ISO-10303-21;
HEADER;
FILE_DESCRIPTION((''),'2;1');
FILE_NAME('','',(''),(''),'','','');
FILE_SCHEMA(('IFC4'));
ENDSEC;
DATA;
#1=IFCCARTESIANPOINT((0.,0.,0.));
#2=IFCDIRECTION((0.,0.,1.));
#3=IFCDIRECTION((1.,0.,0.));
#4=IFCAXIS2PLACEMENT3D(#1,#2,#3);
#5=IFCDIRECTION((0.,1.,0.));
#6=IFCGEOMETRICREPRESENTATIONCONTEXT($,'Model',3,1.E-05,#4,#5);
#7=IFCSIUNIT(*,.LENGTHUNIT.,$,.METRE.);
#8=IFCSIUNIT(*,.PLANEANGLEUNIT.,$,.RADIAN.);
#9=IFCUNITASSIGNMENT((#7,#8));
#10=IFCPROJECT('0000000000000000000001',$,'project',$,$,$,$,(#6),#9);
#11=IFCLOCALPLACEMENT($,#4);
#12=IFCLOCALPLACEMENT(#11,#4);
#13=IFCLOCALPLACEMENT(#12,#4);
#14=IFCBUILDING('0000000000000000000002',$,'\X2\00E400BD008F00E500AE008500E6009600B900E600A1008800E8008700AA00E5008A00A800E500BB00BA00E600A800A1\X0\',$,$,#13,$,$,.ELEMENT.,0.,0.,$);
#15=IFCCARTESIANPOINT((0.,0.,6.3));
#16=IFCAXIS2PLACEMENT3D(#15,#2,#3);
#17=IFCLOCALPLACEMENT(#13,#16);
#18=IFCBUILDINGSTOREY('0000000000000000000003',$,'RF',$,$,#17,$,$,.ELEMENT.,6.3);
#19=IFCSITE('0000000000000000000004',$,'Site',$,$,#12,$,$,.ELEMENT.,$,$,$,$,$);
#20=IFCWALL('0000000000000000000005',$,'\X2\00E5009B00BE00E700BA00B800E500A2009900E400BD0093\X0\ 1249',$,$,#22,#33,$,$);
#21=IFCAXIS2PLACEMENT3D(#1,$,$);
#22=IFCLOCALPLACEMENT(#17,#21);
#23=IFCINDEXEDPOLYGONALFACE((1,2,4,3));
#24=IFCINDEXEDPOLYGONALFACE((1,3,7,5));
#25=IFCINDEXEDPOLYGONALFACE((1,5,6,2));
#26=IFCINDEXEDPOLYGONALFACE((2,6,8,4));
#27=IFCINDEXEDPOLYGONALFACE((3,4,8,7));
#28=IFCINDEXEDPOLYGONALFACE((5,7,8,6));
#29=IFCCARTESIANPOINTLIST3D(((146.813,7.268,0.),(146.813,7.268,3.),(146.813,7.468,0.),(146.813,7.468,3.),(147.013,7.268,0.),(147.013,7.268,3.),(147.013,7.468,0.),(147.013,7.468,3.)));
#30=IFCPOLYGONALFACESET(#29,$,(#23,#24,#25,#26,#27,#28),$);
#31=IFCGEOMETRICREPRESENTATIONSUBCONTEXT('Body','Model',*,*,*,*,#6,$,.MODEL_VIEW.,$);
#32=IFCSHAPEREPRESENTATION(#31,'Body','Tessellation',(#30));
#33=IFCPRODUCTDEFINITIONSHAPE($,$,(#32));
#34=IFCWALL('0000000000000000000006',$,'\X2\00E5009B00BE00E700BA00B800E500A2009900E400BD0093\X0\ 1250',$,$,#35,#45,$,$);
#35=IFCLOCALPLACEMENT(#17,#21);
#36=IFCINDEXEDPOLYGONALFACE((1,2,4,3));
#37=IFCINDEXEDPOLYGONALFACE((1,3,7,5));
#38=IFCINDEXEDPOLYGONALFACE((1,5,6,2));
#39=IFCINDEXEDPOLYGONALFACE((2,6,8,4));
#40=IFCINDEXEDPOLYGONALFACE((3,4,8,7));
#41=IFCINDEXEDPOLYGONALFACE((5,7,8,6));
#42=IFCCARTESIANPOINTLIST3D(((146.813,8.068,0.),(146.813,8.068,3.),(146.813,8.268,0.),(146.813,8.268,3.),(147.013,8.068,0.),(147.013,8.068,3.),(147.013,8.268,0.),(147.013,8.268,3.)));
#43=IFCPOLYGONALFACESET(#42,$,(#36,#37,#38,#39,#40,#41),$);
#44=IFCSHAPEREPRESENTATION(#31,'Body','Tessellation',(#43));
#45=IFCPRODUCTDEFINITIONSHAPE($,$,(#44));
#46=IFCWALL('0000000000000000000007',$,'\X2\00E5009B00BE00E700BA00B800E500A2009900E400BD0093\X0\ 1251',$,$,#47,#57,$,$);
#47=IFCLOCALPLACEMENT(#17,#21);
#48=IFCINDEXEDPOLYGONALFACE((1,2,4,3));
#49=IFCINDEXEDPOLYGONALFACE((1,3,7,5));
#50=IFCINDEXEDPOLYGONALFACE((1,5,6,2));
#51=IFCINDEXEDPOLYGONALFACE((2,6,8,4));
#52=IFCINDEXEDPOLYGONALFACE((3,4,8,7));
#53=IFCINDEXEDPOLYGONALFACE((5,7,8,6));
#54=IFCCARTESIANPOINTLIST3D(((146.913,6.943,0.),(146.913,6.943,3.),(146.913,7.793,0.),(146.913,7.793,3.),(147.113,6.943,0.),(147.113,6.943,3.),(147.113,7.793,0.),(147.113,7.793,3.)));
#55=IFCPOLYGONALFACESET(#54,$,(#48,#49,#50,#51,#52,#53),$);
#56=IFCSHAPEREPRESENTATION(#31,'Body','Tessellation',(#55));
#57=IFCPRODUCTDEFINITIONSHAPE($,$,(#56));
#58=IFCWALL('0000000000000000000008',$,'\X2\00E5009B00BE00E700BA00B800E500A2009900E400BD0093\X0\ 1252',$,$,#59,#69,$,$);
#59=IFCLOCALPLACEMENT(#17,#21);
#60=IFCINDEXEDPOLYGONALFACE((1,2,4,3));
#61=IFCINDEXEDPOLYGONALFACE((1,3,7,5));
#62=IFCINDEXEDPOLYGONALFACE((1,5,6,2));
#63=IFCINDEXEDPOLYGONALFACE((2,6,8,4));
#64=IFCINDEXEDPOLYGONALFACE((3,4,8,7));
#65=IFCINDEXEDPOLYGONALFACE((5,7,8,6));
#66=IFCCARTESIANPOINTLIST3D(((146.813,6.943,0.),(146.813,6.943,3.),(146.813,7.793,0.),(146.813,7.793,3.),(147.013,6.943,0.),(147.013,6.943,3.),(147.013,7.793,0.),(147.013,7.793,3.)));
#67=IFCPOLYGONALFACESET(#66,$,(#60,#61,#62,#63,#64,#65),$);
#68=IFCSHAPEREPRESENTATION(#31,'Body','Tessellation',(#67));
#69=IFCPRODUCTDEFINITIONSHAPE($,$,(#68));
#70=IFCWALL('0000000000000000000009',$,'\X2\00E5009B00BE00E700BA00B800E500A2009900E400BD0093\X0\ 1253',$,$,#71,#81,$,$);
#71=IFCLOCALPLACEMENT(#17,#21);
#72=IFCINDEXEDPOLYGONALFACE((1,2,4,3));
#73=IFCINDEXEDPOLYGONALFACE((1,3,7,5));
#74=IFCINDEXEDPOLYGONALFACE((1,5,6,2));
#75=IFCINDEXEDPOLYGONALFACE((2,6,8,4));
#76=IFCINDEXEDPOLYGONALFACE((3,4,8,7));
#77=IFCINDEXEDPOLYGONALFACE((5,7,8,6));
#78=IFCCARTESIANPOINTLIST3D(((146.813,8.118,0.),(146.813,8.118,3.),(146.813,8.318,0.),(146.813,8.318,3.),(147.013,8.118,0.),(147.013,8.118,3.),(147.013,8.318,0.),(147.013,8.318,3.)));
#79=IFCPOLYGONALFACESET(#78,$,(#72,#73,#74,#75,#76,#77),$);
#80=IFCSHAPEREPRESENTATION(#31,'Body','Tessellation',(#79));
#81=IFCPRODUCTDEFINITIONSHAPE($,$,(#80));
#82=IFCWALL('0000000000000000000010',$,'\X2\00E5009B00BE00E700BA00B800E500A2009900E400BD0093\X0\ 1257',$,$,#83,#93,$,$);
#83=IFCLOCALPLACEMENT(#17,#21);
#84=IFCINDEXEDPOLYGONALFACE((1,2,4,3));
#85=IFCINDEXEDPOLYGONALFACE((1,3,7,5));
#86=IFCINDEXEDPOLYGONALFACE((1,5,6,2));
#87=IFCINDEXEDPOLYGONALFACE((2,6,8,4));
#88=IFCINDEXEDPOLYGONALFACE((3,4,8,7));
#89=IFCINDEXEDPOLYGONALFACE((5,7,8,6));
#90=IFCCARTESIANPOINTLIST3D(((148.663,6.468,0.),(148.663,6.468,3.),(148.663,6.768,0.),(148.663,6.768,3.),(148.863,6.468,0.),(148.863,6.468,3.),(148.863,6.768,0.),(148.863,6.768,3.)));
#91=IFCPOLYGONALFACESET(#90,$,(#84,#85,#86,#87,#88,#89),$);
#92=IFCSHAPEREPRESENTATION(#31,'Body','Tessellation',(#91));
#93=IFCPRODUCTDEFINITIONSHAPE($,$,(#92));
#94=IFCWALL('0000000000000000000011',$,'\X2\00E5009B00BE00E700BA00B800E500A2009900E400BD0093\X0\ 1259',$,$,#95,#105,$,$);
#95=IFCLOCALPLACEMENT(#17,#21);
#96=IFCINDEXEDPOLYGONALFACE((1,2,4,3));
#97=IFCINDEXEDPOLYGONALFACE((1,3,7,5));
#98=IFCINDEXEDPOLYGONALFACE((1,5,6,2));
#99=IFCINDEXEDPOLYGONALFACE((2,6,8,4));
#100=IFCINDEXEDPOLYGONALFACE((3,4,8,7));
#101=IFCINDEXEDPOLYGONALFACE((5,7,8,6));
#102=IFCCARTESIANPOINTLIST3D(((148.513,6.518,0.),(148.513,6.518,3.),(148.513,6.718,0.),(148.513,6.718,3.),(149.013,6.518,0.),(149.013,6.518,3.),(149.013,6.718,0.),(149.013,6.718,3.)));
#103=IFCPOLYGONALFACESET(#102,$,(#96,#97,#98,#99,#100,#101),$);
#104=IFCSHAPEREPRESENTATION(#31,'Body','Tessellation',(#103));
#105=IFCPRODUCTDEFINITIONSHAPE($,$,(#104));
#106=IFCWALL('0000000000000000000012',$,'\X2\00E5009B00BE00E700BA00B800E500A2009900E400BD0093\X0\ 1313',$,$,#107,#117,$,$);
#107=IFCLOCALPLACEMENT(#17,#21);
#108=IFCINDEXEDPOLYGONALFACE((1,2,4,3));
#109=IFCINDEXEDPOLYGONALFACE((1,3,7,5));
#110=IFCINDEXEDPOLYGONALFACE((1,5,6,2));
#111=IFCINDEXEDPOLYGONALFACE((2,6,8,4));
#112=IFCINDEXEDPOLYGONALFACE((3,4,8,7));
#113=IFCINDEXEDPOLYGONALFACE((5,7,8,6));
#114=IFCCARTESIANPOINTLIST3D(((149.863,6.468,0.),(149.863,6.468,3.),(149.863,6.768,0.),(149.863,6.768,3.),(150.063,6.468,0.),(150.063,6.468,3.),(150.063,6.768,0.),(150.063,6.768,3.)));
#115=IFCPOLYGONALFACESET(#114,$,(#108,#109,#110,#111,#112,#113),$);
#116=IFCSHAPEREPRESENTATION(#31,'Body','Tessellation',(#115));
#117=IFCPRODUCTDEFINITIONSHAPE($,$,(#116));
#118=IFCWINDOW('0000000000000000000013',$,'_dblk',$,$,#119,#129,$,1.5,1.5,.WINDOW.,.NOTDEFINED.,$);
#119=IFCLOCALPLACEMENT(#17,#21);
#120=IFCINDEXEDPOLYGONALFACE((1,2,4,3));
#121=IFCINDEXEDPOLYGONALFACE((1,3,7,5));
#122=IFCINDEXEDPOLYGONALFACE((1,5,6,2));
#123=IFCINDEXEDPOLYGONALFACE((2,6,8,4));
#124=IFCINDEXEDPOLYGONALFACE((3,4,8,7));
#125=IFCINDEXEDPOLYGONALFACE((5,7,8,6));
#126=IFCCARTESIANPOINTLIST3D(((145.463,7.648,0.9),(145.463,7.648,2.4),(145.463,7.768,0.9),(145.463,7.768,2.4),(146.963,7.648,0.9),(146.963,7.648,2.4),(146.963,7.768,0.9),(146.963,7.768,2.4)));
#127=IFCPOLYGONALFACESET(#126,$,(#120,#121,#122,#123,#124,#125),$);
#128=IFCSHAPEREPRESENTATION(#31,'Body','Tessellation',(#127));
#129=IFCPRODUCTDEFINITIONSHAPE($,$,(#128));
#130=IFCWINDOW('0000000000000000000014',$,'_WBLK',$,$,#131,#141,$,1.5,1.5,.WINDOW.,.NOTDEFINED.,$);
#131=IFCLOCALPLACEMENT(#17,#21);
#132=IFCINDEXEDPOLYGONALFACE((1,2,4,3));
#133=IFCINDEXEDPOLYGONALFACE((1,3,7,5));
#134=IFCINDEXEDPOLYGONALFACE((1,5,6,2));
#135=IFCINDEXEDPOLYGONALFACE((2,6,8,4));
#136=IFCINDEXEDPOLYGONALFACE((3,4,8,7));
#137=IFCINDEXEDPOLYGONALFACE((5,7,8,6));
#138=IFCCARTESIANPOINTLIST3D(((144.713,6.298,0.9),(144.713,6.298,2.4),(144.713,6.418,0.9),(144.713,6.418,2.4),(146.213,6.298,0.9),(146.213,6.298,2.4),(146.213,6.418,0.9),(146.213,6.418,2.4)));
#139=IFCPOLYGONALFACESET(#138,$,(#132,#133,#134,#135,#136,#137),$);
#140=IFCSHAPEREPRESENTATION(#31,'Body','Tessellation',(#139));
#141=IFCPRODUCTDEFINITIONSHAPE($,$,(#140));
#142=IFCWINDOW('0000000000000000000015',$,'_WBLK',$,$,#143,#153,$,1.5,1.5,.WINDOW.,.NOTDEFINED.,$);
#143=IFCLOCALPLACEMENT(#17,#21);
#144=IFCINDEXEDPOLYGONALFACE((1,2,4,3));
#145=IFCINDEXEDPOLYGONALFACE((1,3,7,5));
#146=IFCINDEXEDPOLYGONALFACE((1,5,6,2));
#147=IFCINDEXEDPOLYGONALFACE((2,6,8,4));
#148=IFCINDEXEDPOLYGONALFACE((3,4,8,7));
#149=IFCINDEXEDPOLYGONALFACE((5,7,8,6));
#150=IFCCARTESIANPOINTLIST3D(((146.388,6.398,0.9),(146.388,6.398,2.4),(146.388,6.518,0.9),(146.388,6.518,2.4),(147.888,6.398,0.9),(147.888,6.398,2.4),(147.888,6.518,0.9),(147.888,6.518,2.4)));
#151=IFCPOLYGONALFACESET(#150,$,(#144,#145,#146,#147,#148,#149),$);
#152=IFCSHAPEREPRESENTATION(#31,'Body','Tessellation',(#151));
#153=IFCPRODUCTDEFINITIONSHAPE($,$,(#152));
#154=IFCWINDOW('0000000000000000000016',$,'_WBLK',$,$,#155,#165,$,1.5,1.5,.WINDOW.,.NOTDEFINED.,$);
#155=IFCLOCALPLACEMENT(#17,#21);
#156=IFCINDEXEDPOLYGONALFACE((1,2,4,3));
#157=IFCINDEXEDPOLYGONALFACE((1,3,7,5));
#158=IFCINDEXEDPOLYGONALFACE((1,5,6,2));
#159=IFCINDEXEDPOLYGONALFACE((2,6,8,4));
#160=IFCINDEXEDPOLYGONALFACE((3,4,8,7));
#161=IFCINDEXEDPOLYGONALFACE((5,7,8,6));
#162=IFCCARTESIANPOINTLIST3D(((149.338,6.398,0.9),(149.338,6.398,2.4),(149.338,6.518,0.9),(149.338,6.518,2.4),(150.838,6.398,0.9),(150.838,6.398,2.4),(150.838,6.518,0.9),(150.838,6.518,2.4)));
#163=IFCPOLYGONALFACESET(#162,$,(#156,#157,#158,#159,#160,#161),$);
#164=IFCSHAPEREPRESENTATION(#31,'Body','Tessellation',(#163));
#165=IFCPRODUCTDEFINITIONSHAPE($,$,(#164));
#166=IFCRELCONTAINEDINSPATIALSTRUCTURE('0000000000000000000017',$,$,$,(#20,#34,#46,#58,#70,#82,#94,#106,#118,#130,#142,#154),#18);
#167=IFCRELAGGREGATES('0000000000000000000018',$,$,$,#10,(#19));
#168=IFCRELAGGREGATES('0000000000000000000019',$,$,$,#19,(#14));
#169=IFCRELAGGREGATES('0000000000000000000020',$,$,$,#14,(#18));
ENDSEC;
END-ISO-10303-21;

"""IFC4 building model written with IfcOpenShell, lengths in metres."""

from ifc_helpers import new_model, si_unit, direction, frame, frame_2d, origin_with_axes, place, context, subcontext, project, spatial, rectangle, extrude, element, save


model = new_model("IFC4")

# Units and contexts
model_context = context("Model", 3, precision=1e-05, world=origin_with_axes(), true_north=direction((0.0, 1.0, 0.0)))
body_context = subcontext(model_context, "Body", "Model", "MODEL_VIEW")
ifc_project = project(units=[si_unit("LENGTHUNIT", "METRE"), si_unit("PLANEANGLEUNIT", "RADIAN")], contexts=[model_context])

# Site, building, storey
placement = place(None, origin_with_axes())
site_placement = place(placement, origin_with_axes())
site = spatial("IfcSite", under=ifc_project, at=site_placement, Name="Site", CompositionType="ELEMENT")
building_placement = place(site_placement, origin_with_axes())
building = spatial("IfcBuilding", under=site, at=building_placement, Name="ä½\u008få®\u0085æ\u0096¹æ¡\u0088è\u0087ªå\u008a¨å»ºæ¨¡", CompositionType="ELEMENT", ElevationOfRefHeight=0.0, ElevationOfTerrain=0.0)
storey_placement = place(building_placement, frame((0.0, 0.0, 6.3), z_axis=(0.0, 0.0, 1.0), x_axis=(1.0, 0.0, 0.0)))
storey = spatial("IfcBuildingStorey", under=building, at=storey_placement, Name="RF", CompositionType="ELEMENT", Elevation=6.3)

# Walls
for number, where, z_axis, x_axis, name in (
    (1, (146.913, 7.368, 0.0), (0.0, 0.0, 1.0), (1.0, 0.0, 0.0), "å\u009b¾çº¸å¢\u0099ä½\u0093 1249"),
    (2, (146.913, 8.168, 0.0), (0.0, 0.0, 1.0), (1.0, 0.0, 0.0), "å\u009b¾çº¸å¢\u0099ä½\u0093 1250"),
):
    element("IfcWall", number, at=place(storey_placement, frame(where, z_axis=z_axis, x_axis=x_axis)), inside=storey, Name=name, context=body_context, shape_type="SweptSolid", body=[
        extrude(rectangle(XDim=0.2, YDim=0.2, at=frame_2d((0.0, 0.0), x_axis=(1.0, 0.0, 0.0))), frame((0.0, 0.0, 0.0), z_axis=(0.0, 0.0, 1.0)), (0.0, 0.0, 1.0), 3.0),
    ])
for number, where, z_axis, x_axis, name in (
    (3, (147.013, 7.368, 0.0), (0.0, 0.0, 1.0), (0.0, -1.0, 0.0), "å\u009b¾çº¸å¢\u0099ä½\u0093 1251"),
    (4, (146.913, 7.368, 0.0), (0.0, 0.0, 1.0), (0.0, -1.0, 0.0), "å\u009b¾çº¸å¢\u0099ä½\u0093 1252"),
):
    element("IfcWall", number, at=place(storey_placement, frame(where, z_axis=z_axis, x_axis=x_axis)), inside=storey, Name=name, context=body_context, shape_type="SweptSolid", body=[
        extrude(rectangle(XDim=0.85, YDim=0.2, at=frame_2d((0.0, 0.0), x_axis=(1.0, 0.0, 0.0))), frame((0.0, 0.0, 0.0), z_axis=(0.0, 0.0, 1.0)), (0.0, 0.0, 1.0), 3.0),
    ])
wall_1_placement = place(storey_placement, frame((146.913, 8.218, 0.0), z_axis=(0.0, 0.0, 1.0), x_axis=(0.0, -1.0, 0.0)))
element("IfcWall", 5, at=wall_1_placement, inside=storey, Name="å\u009b¾çº¸å¢\u0099ä½\u0093 1253", context=body_context, shape_type="SweptSolid", body=[
    extrude(rectangle(XDim=0.2, YDim=0.2, at=frame_2d((0.0, 0.0), x_axis=(1.0, 0.0, 0.0))), frame((0.0, 0.0, 0.0), z_axis=(0.0, 0.0, 1.0)), (0.0, 0.0, 1.0), 3.0),
])
wall_2_placement = place(storey_placement, frame((148.763, 6.618, 0.0), z_axis=(0.0, 0.0, 1.0), x_axis=(0.0, -1.0, 0.0)))
element("IfcWall", 6, at=wall_2_placement, inside=storey, Name="å\u009b¾çº¸å¢\u0099ä½\u0093 1257", context=body_context, shape_type="SweptSolid", body=[
    extrude(rectangle(XDim=0.3, YDim=0.2, at=frame_2d((0.0, 0.0), x_axis=(1.0, 0.0, 0.0))), frame((0.0, 0.0, 0.0), z_axis=(0.0, 0.0, 1.0)), (0.0, 0.0, 1.0), 3.0),
])
wall_3_placement = place(storey_placement, frame((148.763, 6.618, 0.0), z_axis=(0.0, 0.0, 1.0), x_axis=(1.0, 0.0, 0.0)))
element("IfcWall", 7, at=wall_3_placement, inside=storey, Name="å\u009b¾çº¸å¢\u0099ä½\u0093 1259", context=body_context, shape_type="SweptSolid", body=[
    extrude(rectangle(XDim=0.5, YDim=0.2, at=frame_2d((0.0, 0.0), x_axis=(1.0, 0.0, 0.0))), frame((0.0, 0.0, 0.0), z_axis=(0.0, 0.0, 1.0)), (0.0, 0.0, 1.0), 3.0),
])
wall_4_placement = place(storey_placement, frame((149.963, 6.618, 0.0), z_axis=(0.0, 0.0, 1.0), x_axis=(0.0, -1.0, 0.0)))
element("IfcWall", 8, at=wall_4_placement, inside=storey, Name="å\u009b¾çº¸å¢\u0099ä½\u0093 1313", context=body_context, shape_type="SweptSolid", body=[
    extrude(rectangle(XDim=0.3, YDim=0.2, at=frame_2d((0.0, 0.0), x_axis=(1.0, 0.0, 0.0))), frame((0.0, 0.0, 0.0), z_axis=(0.0, 0.0, 1.0)), (0.0, 0.0, 1.0), 3.0),
])

# Windows
for number, where, z_axis, x_axis, name in (
    (9, (146.213, 7.708, 0.9), (0.0, 0.0, 1.0), (1.0, 0.0, 0.0), "_dblk"),
    (10, (145.463, 6.358, 0.9), (0.0, 0.0, 1.0), (1.0, 0.0, 0.0), "_WBLK"),
    (11, (147.138, 6.458, 0.9), (0.0, 0.0, 1.0), (1.0, 0.0, 0.0), "_WBLK"),
    (12, (150.088, 6.458, 0.9), (0.0, 0.0, 1.0), (1.0, 0.0, 0.0), "_WBLK"),
):
    element("IfcWindow", number, at=place(storey_placement, frame(where, z_axis=z_axis, x_axis=x_axis)), inside=storey, Name=name, OverallHeight=1.5, OverallWidth=1.5, PartitioningType="NOTDEFINED", PredefinedType="WINDOW", context=body_context, shape_type="SweptSolid", body=[
        extrude(rectangle(XDim=1.5, YDim=0.12, at=frame_2d((0.0, 0.0), x_axis=(1.0, 0.0, 0.0))), frame((0.0, 0.0, 0.0), z_axis=(0.0, 0.0, 1.0)), (0.0, 0.0, 1.0), 1.5),
    ])

save(model, "model.ifc")
